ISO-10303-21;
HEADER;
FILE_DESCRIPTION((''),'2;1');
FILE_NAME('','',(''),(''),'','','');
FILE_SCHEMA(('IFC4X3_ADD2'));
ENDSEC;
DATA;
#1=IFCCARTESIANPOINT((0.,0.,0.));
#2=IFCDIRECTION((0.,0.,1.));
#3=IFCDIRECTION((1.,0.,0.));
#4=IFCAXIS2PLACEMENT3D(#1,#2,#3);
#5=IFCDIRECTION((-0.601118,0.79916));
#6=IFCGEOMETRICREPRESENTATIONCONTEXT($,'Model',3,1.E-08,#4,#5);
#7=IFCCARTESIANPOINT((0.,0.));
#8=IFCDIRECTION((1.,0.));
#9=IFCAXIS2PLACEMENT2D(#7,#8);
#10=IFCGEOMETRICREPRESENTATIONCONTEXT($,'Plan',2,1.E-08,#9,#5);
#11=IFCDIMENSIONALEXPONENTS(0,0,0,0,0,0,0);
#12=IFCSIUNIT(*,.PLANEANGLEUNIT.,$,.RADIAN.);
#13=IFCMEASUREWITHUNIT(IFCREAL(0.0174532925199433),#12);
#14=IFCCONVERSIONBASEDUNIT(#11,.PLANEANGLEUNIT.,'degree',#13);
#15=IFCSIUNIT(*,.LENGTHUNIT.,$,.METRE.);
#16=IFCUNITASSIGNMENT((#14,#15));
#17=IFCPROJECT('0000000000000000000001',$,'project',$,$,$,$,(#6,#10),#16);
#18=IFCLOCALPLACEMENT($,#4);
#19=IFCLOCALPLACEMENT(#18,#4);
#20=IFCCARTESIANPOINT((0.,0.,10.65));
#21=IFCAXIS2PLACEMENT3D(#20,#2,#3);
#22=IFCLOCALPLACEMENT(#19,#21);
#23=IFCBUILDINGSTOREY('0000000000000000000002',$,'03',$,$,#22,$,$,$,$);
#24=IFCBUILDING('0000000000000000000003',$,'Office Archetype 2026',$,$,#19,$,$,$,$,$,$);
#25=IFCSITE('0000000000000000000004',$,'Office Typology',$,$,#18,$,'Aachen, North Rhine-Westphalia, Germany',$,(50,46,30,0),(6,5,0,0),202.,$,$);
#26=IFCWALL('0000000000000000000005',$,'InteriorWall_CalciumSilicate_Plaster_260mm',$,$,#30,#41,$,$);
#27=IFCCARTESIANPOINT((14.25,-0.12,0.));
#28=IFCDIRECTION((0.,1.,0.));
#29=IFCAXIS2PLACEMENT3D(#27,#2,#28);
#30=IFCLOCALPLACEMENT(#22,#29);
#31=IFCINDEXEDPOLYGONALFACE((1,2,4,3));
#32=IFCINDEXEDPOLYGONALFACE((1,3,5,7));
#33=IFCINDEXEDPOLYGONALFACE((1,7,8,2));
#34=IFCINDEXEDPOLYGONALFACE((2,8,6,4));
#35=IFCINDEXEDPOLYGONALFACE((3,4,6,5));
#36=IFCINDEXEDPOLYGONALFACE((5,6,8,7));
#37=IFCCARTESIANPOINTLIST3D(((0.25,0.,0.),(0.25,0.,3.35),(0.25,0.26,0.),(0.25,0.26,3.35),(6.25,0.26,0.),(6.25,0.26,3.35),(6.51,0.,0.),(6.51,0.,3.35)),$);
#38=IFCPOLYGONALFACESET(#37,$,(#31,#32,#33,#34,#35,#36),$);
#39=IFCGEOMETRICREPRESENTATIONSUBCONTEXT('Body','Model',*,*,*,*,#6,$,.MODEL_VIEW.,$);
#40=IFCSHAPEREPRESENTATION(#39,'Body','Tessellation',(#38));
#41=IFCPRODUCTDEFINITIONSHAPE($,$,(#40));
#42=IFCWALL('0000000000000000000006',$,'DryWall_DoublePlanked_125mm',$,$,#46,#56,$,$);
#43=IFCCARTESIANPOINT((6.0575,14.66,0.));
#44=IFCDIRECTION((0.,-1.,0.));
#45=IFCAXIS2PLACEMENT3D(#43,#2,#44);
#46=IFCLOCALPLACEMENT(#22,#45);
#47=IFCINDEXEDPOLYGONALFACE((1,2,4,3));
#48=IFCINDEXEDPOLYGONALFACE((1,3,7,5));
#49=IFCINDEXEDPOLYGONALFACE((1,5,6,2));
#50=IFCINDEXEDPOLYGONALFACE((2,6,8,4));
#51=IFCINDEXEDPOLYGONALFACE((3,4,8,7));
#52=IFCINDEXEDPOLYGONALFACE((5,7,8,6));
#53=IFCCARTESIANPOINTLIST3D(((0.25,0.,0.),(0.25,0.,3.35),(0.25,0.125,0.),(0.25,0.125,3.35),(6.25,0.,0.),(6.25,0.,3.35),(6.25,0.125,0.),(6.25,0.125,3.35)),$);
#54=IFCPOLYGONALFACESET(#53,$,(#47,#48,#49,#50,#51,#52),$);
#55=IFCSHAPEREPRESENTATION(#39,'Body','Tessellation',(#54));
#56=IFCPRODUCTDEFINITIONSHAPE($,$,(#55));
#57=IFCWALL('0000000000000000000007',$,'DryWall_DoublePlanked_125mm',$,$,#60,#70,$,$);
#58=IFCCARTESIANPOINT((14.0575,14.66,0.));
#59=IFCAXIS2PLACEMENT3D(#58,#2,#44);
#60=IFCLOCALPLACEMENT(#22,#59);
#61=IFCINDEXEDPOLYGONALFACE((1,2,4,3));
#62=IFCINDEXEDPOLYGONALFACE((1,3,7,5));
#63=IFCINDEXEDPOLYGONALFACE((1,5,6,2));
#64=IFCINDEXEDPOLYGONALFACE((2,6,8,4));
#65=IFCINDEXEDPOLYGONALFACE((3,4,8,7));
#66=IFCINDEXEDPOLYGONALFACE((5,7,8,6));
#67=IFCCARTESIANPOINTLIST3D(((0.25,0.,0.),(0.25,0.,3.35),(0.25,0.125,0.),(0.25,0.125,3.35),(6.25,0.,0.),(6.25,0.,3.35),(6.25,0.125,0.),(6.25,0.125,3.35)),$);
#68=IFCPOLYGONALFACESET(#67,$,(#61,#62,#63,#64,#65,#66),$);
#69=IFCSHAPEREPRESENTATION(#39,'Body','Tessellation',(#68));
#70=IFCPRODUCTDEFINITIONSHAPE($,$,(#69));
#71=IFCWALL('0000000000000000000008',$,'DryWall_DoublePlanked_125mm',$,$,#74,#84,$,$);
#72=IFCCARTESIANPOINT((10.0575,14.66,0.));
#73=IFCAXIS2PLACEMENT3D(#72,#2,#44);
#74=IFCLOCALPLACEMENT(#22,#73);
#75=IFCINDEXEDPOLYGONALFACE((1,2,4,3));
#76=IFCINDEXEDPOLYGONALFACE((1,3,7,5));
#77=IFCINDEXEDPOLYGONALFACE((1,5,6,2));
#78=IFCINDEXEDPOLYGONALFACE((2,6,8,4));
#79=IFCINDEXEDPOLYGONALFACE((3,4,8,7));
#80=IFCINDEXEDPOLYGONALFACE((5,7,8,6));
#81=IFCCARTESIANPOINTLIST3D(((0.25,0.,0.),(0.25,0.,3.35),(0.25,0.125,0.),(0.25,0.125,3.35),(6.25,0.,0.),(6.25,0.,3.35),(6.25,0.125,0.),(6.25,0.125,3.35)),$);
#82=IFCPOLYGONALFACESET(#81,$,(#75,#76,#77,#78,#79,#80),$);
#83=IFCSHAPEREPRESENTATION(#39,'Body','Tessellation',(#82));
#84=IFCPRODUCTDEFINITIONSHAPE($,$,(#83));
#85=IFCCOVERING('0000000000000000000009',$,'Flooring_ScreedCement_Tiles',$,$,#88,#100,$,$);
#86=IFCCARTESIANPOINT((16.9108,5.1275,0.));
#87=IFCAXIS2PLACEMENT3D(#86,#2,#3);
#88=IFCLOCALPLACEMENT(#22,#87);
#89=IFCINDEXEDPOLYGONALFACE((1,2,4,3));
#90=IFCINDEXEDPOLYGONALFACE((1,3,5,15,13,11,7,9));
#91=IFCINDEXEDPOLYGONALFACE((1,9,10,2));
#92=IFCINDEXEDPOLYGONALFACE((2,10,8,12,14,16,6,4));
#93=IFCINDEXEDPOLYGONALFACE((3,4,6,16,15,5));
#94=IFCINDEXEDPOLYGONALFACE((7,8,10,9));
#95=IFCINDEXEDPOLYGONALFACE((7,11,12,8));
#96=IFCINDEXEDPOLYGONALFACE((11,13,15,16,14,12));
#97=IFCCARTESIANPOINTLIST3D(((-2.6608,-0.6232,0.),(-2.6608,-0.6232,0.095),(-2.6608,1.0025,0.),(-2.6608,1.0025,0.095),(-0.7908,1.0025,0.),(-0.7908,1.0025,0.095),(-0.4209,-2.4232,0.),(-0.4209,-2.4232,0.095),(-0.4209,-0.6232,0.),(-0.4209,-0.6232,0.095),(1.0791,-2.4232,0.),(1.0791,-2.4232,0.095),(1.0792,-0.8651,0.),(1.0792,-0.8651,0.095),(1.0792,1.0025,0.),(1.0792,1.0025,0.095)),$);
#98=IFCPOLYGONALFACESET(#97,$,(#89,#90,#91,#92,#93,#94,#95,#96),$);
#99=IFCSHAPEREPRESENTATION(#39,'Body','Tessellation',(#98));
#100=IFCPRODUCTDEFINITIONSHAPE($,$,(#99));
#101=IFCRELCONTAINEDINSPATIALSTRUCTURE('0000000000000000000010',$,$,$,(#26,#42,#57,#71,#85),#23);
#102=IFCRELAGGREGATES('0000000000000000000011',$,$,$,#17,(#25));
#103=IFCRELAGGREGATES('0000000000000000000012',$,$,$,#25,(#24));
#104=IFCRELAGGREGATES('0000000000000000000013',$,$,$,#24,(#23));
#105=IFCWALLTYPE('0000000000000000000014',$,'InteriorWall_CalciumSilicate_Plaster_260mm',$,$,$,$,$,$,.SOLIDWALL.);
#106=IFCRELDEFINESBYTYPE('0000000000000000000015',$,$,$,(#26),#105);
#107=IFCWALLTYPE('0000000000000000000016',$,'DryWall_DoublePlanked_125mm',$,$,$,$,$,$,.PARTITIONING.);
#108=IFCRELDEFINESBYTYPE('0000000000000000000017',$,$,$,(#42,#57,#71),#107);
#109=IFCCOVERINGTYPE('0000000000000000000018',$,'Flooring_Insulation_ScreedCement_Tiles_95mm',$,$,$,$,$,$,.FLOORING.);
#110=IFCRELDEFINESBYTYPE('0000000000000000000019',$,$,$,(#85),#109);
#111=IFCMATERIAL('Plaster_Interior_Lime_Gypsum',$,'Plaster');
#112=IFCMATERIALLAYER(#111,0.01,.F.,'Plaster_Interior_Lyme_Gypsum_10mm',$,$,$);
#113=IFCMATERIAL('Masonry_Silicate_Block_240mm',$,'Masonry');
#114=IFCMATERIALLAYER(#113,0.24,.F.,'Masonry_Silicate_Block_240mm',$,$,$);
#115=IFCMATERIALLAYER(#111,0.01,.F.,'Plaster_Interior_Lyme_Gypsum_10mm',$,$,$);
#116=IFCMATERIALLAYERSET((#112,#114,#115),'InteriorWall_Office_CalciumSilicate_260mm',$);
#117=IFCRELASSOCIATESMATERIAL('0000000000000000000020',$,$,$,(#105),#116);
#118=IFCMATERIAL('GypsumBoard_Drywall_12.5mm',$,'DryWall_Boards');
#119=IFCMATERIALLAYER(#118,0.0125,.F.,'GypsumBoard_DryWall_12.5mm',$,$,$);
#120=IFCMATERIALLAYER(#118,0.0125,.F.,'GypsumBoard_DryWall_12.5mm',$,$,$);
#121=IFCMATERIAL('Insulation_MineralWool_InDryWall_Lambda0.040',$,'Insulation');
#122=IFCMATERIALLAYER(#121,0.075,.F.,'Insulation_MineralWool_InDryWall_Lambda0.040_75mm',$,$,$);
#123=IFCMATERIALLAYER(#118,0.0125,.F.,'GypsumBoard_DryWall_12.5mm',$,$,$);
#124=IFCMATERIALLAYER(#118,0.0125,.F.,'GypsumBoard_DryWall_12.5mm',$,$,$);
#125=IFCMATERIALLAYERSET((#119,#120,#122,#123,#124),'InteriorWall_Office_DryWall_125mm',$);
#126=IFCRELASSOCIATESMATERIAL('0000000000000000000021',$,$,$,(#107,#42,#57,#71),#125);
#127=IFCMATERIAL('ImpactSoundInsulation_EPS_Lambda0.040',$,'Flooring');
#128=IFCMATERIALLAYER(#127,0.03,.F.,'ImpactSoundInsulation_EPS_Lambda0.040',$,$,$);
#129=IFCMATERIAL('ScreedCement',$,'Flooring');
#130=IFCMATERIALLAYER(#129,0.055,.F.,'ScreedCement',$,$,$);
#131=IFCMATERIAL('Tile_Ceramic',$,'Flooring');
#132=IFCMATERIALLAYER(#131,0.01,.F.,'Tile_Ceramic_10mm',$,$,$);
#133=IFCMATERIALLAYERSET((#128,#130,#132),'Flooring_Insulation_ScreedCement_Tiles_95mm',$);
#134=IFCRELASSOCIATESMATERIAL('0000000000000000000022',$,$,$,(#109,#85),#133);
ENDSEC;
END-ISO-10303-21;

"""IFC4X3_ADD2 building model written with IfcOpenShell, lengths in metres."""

from ifc_helpers import new_model, entity, si_unit, converted_unit, direction, frame, origin_with_axes, origin_2d_with_axis, place, context, subcontext, project, spatial, line, indexed_curve, outline, extrude, material, layer, layer_set, layer_usage, type_object, element, save


model = new_model("IFC4X3_ADD2")

# Units and contexts
model_context = context("Model", 3, precision=1e-08, world=origin_with_axes(), true_north=direction((-0.601118, 0.79916)))
plan_context = context("Plan", 2, precision=1e-08, world=origin_2d_with_axis(), true_north=direction((-0.601118, 0.79916)))
body_context = subcontext(model_context, "Body", "Model", "MODEL_VIEW")
ifc_project = project(units=[converted_unit("PLANEANGLEUNIT", "degree", entity("IfcReal", 0.0174532925199433), si_unit("PLANEANGLEUNIT", "RADIAN"), dimensions=[0, 0, 0, 0, 0, 0, 0]), si_unit("LENGTHUNIT", "METRE")], contexts=[model_context, plan_context])

# Site, building, storey
site_placement = place(None, origin_with_axes())
site = spatial("IfcSite", under=ifc_project, at=site_placement, Name="Office Typology", LongName="Aachen, North Rhine-Westphalia, Germany", RefLatitude=(50, 46, 30, 0), RefLongitude=(6, 5, 0, 0), RefElevation=202.0)
building_placement = place(site_placement, origin_with_axes())
building = spatial("IfcBuilding", under=site, at=building_placement, Name="Office Archetype 2026")
storey_placement = place(building_placement, frame((0.0, 0.0, 10.65), z_axis=(0.0, 0.0, 1.0), x_axis=(1.0, 0.0, 0.0)))
storey = spatial("IfcBuildingStorey", under=building, at=storey_placement, Name="03")

# Shared definitions
ifc_material_1 = material(Name="Plaster_Interior_Lime_Gypsum", Category="Plaster")
ifc_layer_1 = layer(ifc_material_1, 0.01, ventilated=False, Name="Plaster_Interior_Lyme_Gypsum_10mm")
ifc_material_2 = material(Name="Masonry_Silicate_Block_240mm", Category="Masonry")
ifc_layer_2 = layer(ifc_material_2, 0.24, ventilated=False, Name="Masonry_Silicate_Block_240mm")
ifc_layer_3 = layer(ifc_material_1, 0.01, ventilated=False, Name="Plaster_Interior_Lyme_Gypsum_10mm")
ifc_layer_set_1 = layer_set([ifc_layer_1, ifc_layer_2, ifc_layer_3], Name="InteriorWall_Office_CalciumSilicate_260mm")
wall_type_1 = type_object("IfcWallType", Name="InteriorWall_CalciumSilicate_Plaster_260mm", PredefinedType="SOLIDWALL", material=ifc_layer_set_1)

# Wall
wall_1_placement = place(storey_placement, frame((14.25, -0.12, 0.0), z_axis=(0.0, 0.0, 1.0), x_axis=(0.0, 1.0, 0.0)))
element("IfcWall", 1, at=wall_1_placement, inside=storey, type_object=wall_type_1, Name="InteriorWall_CalciumSilicate_Plaster_260mm", context=body_context, shape_type="SweptSolid", body=[
    extrude(outline(indexed_curve([(0.25, 0.0), (0.25, 0.26), (6.25, 0.26), (6.51, 0.0)], segments=[line(1, 2, 3, 4, 1)])), origin_with_axes(), (0.0, 0.0, 1.0), 3.35),
])

# Walls
ifc_material_3 = material(Name="GypsumBoard_Drywall_12.5mm", Category="DryWall_Boards")
ifc_layer_4 = layer(ifc_material_3, 0.0125, ventilated=False, Name="GypsumBoard_DryWall_12.5mm")
ifc_layer_5 = layer(ifc_material_3, 0.0125, ventilated=False, Name="GypsumBoard_DryWall_12.5mm")
ifc_material_4 = material(Name="Insulation_MineralWool_InDryWall_Lambda0.040", Category="Insulation")
ifc_layer_6 = layer(ifc_material_4, 0.075, ventilated=False, Name="Insulation_MineralWool_InDryWall_Lambda0.040_75mm")
ifc_layer_7 = layer(ifc_material_3, 0.0125, ventilated=False, Name="GypsumBoard_DryWall_12.5mm")
ifc_layer_8 = layer(ifc_material_3, 0.0125, ventilated=False, Name="GypsumBoard_DryWall_12.5mm")
ifc_layer_set_2 = layer_set([ifc_layer_4, ifc_layer_5, ifc_layer_6, ifc_layer_7, ifc_layer_8], Name="InteriorWall_Office_DryWall_125mm")
ifc_layer_usage_1 = layer_usage(ifc_layer_set_2, "AXIS2", "POSITIVE", 0.0)
wall_type_2 = type_object("IfcWallType", Name="DryWall_DoublePlanked_125mm", PredefinedType="PARTITIONING", material=ifc_layer_set_2)
wall_2_placement = place(storey_placement, frame((6.0575, 14.66, 0.0), z_axis=(0.0, 0.0, 1.0), x_axis=(0.0, -1.0, 0.0)))
element("IfcWall", 2, at=wall_2_placement, inside=storey, type_object=wall_type_2, material=ifc_layer_usage_1, Name="DryWall_DoublePlanked_125mm", context=body_context, shape_type="SweptSolid", body=[
    extrude(outline(indexed_curve([(0.25, 0.0), (0.25, 0.125), (6.25, 0.125), (6.25, 0.0)], segments=[line(1, 2, 3, 4, 1)])), origin_with_axes(), (0.0, 0.0, 1.0), 3.35),
])
ifc_layer_usage_2 = layer_usage(ifc_layer_set_2, "AXIS2", "POSITIVE", 0.0)
wall_3_placement = place(storey_placement, frame((14.0575, 14.66, 0.0), z_axis=(0.0, 0.0, 1.0), x_axis=(0.0, -1.0, 0.0)))
element("IfcWall", 3, at=wall_3_placement, inside=storey, type_object=wall_type_2, material=ifc_layer_usage_2, Name="DryWall_DoublePlanked_125mm", context=body_context, shape_type="SweptSolid", body=[
    extrude(outline(indexed_curve([(0.25, 0.0), (0.25, 0.125), (6.25, 0.125), (6.25, 0.0)], segments=[line(1, 2, 3, 4, 1)])), origin_with_axes(), (0.0, 0.0, 1.0), 3.35),
])
ifc_layer_usage_3 = layer_usage(ifc_layer_set_2, "AXIS2", "POSITIVE", 0.0)
wall_4_placement = place(storey_placement, frame((10.0575, 14.66, 0.0), z_axis=(0.0, 0.0, 1.0), x_axis=(0.0, -1.0, 0.0)))
element("IfcWall", 4, at=wall_4_placement, inside=storey, type_object=wall_type_2, material=ifc_layer_usage_3, Name="DryWall_DoublePlanked_125mm", context=body_context, shape_type="SweptSolid", body=[
    extrude(outline(indexed_curve([(0.25, 0.0), (0.25, 0.125), (6.25, 0.125), (6.25, 0.0)], segments=[line(1, 2, 3, 4, 1)])), origin_with_axes(), (0.0, 0.0, 1.0), 3.35),
])

# Covering
ifc_material_5 = material(Name="ImpactSoundInsulation_EPS_Lambda0.040", Category="Flooring")
ifc_layer_9 = layer(ifc_material_5, 0.03, ventilated=False, Name="ImpactSoundInsulation_EPS_Lambda0.040")
ifc_material_6 = material(Name="ScreedCement", Category="Flooring")
ifc_layer_10 = layer(ifc_material_6, 0.055, ventilated=False, Name="ScreedCement")
ifc_material_7 = material(Name="Tile_Ceramic", Category="Flooring")
ifc_layer_11 = layer(ifc_material_7, 0.01, ventilated=False, Name="Tile_Ceramic_10mm")
ifc_layer_set_3 = layer_set([ifc_layer_9, ifc_layer_10, ifc_layer_11], Name="Flooring_Insulation_ScreedCement_Tiles_95mm")
ifc_layer_usage_4 = layer_usage(ifc_layer_set_3, "AXIS3", "POSITIVE", 0.0)
covering_type = type_object("IfcCoveringType", Name="Flooring_Insulation_ScreedCement_Tiles_95mm", PredefinedType="FLOORING", material=ifc_layer_set_3)
covering_placement = place(storey_placement, frame((16.9108, 5.1275, 0.0), z_axis=(0.0, 0.0, 1.0), x_axis=(1.0, 0.0, 0.0)))
element("IfcCovering", 5, at=covering_placement, inside=storey, type_object=covering_type, material=ifc_layer_usage_4, Name="Flooring_ScreedCement_Tiles", context=body_context, shape_type="SweptSolid", body=[
    extrude(outline(indexed_curve([(-0.7908, 1.0025), (-2.6608, 1.0025), (-2.6608, -0.6232), (-0.4209, -0.6232), (-0.4209, -2.4232), (1.0791, -2.4232), (1.0792, -0.8651), (1.0792, 1.0025), (-0.7908, 1.0025)])), None, (0.0, 0.0, 1.0), 0.095),
])

save(model, "model.ifc")
